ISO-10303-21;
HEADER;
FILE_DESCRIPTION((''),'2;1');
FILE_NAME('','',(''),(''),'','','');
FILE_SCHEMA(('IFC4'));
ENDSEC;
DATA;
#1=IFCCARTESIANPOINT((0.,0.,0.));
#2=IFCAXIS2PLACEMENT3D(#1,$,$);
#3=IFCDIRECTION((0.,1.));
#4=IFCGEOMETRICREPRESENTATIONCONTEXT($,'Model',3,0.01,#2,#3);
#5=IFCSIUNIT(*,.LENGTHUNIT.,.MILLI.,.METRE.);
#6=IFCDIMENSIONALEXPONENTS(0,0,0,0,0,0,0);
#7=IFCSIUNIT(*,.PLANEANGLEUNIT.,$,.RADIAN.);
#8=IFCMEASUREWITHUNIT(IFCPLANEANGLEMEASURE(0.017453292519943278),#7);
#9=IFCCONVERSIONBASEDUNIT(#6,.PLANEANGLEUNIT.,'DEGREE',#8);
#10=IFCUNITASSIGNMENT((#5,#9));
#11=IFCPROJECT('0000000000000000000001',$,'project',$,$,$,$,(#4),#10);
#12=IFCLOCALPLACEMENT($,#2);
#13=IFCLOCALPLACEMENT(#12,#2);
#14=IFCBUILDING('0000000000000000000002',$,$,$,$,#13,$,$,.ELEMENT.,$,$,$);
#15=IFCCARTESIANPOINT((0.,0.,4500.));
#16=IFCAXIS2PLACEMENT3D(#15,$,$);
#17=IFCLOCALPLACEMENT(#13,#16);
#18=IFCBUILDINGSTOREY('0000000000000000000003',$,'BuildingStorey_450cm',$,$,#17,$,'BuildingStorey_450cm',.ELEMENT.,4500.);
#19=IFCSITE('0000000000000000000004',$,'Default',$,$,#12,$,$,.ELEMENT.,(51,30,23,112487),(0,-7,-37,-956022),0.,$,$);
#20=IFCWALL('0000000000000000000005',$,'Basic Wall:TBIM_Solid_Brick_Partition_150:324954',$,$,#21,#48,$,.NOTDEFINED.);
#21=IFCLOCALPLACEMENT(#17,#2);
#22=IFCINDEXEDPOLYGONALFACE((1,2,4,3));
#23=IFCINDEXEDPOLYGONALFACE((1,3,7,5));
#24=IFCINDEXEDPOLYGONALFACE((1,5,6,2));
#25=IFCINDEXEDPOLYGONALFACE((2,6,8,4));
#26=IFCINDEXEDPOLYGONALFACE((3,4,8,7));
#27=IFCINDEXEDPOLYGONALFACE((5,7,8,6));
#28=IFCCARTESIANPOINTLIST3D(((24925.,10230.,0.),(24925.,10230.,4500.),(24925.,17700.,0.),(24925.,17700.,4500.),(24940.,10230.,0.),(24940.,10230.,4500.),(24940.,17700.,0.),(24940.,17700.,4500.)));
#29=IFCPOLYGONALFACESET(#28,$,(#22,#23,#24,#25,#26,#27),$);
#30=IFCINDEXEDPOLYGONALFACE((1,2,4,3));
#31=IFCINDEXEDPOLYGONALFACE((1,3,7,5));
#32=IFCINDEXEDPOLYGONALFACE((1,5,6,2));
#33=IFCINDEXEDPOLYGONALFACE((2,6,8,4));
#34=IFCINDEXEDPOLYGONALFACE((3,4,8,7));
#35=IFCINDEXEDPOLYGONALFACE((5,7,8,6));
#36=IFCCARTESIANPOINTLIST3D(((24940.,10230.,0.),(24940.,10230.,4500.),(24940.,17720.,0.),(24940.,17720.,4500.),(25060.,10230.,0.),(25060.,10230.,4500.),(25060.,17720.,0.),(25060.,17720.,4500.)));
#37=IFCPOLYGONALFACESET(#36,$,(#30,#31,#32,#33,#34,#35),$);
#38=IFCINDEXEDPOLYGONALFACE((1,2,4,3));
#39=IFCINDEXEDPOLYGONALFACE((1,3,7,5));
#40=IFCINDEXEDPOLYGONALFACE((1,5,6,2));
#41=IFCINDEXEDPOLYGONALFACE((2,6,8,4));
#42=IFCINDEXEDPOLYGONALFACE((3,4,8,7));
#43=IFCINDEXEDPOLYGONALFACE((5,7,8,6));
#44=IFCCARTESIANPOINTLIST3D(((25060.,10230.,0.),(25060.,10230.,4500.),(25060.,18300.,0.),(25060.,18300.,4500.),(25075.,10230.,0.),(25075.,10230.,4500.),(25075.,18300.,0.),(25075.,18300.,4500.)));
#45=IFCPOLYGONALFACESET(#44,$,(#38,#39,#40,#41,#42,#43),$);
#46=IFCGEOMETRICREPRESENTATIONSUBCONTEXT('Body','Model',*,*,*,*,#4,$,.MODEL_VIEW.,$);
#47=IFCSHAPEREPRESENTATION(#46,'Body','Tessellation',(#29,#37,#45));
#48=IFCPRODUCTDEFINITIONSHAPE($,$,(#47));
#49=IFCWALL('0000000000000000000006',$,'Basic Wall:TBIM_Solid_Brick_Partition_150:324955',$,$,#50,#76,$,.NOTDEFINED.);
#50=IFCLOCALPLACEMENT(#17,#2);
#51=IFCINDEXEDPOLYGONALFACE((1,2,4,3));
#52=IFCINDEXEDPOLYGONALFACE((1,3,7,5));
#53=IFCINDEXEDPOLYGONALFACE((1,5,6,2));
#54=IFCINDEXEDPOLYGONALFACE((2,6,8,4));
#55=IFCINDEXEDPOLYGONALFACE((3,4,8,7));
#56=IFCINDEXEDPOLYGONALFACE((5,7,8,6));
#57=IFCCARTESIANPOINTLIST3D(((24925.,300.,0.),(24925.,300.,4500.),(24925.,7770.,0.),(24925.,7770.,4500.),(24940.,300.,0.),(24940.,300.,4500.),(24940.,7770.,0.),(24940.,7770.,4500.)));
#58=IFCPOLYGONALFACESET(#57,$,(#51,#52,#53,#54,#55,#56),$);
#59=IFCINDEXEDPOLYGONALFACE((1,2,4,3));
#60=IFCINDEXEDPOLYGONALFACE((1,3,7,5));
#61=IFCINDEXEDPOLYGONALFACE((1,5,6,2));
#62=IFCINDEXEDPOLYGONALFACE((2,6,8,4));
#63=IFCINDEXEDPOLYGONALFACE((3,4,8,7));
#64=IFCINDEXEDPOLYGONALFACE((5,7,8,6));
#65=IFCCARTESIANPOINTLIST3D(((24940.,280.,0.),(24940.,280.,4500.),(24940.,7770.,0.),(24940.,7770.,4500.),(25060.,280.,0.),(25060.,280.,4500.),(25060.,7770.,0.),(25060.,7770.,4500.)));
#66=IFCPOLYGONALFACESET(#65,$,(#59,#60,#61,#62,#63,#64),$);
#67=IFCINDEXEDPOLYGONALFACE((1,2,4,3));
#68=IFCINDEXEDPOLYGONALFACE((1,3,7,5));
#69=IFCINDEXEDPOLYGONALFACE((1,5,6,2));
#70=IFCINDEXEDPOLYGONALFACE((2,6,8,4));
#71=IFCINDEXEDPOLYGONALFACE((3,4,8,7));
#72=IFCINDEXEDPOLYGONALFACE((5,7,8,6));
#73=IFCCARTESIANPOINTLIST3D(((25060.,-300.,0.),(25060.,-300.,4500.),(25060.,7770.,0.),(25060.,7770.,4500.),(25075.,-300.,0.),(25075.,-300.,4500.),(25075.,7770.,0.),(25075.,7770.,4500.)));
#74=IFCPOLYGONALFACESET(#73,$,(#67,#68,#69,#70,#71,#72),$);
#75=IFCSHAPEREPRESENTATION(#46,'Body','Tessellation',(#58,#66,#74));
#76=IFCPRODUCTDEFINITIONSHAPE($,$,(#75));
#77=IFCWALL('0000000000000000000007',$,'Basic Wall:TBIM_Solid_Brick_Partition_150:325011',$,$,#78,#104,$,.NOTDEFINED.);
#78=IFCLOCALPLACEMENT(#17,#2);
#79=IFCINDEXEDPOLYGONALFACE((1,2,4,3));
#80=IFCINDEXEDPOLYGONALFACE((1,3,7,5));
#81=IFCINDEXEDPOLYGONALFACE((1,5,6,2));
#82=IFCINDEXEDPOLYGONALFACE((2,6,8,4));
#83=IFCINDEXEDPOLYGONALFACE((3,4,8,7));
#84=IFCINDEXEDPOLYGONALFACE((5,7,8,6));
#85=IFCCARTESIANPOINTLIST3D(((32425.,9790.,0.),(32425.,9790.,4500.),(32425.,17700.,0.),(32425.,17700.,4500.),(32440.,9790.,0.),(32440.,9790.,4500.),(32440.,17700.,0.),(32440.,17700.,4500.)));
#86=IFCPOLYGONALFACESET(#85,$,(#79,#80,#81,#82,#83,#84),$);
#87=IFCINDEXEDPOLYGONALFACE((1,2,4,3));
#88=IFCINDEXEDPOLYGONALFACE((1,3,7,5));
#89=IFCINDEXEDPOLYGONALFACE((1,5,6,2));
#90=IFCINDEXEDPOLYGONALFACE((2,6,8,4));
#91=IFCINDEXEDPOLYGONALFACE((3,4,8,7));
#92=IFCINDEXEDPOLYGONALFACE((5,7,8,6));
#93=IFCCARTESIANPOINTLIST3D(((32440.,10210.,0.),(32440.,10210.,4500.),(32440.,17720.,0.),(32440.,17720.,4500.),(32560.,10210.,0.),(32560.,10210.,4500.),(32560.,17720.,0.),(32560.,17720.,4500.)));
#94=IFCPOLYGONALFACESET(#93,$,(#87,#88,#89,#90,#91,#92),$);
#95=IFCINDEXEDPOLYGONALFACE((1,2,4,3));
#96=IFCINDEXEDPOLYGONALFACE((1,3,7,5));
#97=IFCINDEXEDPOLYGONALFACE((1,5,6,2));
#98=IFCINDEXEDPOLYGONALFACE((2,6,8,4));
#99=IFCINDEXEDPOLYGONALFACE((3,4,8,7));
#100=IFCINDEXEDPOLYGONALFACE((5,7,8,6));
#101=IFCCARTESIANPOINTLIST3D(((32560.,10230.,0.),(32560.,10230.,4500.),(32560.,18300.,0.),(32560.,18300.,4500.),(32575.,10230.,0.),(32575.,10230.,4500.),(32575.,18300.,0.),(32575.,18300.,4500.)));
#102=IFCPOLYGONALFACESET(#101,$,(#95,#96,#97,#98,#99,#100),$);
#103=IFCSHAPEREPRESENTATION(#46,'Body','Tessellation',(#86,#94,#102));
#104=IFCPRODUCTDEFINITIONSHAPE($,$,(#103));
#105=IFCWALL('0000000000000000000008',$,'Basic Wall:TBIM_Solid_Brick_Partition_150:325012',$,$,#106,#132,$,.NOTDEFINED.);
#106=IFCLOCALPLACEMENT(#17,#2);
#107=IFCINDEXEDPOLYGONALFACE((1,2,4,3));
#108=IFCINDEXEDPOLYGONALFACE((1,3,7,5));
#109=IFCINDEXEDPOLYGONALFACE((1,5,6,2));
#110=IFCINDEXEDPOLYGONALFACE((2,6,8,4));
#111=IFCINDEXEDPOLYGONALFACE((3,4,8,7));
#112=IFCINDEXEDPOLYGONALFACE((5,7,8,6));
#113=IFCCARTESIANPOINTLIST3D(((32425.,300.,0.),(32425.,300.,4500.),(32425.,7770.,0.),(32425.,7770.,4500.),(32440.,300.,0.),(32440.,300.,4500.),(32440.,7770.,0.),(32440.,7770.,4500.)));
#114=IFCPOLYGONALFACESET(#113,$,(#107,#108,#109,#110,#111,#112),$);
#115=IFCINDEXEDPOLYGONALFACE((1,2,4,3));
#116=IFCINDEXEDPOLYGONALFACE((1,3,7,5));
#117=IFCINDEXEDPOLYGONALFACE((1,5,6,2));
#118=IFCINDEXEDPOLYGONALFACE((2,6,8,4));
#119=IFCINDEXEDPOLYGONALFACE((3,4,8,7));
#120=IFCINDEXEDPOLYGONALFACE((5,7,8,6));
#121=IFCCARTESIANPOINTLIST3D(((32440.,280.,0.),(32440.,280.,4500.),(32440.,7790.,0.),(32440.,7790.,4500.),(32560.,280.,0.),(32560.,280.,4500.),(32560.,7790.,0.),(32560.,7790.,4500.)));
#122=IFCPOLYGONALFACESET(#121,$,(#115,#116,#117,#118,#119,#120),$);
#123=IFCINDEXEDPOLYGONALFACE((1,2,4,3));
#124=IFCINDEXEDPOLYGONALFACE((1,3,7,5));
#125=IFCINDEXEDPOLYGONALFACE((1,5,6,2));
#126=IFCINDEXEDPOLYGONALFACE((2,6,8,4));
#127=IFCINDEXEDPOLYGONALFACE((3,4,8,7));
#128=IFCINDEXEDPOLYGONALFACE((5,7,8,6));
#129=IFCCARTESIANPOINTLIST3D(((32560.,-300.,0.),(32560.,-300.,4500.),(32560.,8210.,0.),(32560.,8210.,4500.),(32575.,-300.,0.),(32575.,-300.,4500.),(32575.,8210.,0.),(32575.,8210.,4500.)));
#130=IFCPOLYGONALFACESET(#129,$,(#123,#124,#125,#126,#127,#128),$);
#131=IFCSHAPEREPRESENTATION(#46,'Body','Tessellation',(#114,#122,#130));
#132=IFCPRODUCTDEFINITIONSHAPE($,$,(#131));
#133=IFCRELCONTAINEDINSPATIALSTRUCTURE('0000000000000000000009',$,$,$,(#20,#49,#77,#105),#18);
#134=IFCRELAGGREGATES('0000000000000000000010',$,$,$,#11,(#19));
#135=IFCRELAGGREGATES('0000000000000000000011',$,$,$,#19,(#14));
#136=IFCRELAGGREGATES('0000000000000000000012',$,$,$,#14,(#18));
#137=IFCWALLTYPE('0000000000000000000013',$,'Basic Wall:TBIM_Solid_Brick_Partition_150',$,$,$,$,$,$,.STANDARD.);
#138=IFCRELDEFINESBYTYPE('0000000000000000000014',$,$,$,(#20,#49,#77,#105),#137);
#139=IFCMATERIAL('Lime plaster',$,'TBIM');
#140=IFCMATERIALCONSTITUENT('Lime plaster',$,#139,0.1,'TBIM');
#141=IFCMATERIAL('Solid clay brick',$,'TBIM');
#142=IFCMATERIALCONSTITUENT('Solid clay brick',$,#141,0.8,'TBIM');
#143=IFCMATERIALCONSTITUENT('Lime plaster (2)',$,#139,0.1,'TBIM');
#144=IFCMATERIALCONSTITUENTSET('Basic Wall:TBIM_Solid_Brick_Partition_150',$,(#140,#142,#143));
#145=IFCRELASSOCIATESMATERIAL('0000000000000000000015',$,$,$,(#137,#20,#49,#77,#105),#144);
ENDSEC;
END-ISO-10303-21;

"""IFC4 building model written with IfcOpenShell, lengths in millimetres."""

from ifc_helpers import new_model, entity, si_unit, converted_unit, direction, frame, origin, place, context, subcontext, project, spatial, indexed_curve, outline, extrude, material, constituent, constituent_set, type_object, element, save


model = new_model("IFC4")

# Units and contexts
model_context = context("Model", 3, precision=0.01, world=origin(), true_north=direction((0.0, 1.0)))
body_context = subcontext(model_context, "Body", "Model", "MODEL_VIEW")
ifc_project = project(units=[si_unit("LENGTHUNIT", "METRE", prefix="MILLI"), converted_unit("PLANEANGLEUNIT", "DEGREE", entity("IfcPlaneAngleMeasure", 0.017453292519943278), si_unit("PLANEANGLEUNIT", "RADIAN"), dimensions=[0, 0, 0, 0, 0, 0, 0])], contexts=[model_context])

# Site, building, storey
site_placement = place(None, origin())
site = spatial("IfcSite", under=ifc_project, at=site_placement, Name="Default", CompositionType="ELEMENT", RefLatitude=(51, 30, 23, 112487), RefLongitude=(0, -7, -37, -956022), RefElevation=0.0)
building_placement = place(site_placement, origin())
building = spatial("IfcBuilding", under=site, at=building_placement, CompositionType="ELEMENT")
storey_placement = place(building_placement, frame((0.0, 0.0, 4500.0)))
storey = spatial("IfcBuildingStorey", under=building, at=storey_placement, Name="BuildingStorey_450cm", LongName="BuildingStorey_450cm", CompositionType="ELEMENT", Elevation=4500.0)

# Shared definitions
ifc_material_1 = material(Name="Solid clay brick", Category="TBIM")
ifc_material_2 = material(Name="Lime plaster", Category="TBIM")

# Walls
ifc_constituent_1 = constituent(ifc_material_2, Name="Lime plaster", Category="TBIM", fraction=0.1)
ifc_constituent_2 = constituent(ifc_material_1, Name="Solid clay brick", Category="TBIM", fraction=0.8)
ifc_constituent_3 = constituent(ifc_material_2, Name="Lime plaster (2)", Category="TBIM", fraction=0.1)
ifc_constituent_set_1 = constituent_set(constituents=[ifc_constituent_1, ifc_constituent_2, ifc_constituent_3], Name="Basic Wall:TBIM_Solid_Brick_Partition_150")
wall_type_1 = type_object("IfcWallType", Name="Basic Wall:TBIM_Solid_Brick_Partition_150", PredefinedType="STANDARD", material=ifc_constituent_set_1)
wall_1_placement = place(storey_placement, frame((25000.0, 10230.0, 0.0), z_axis=(0.0, 0.0, 1.0), x_axis=(0.0, 1.0, 0.0)))
element("IfcWall", 1, at=wall_1_placement, inside=storey, type_object=wall_type_1, material=ifc_constituent_set_1, Name="Basic Wall:TBIM_Solid_Brick_Partition_150:324954", PredefinedType="NOTDEFINED", context=body_context, shape_type="SweptSolid", body=[
    extrude(outline(indexed_curve([(-7.5, -3735.0), (7.5, -3735.0), (7.5, 3735.0), (-7.5, 3735.0), (-7.5, -3735.0)], self_intersect=False)), frame((3735.0, 67.5, 0.0), z_axis=(0.0, 0.0, 1.0), x_axis=(0.0, -1.0, 0.0)), (0.0, 0.0, 1.0), 4500.0),
    extrude(outline(indexed_curve([(-3745.0, -60.0), (3745.0, -60.0), (3745.0, 60.0), (-3745.0, 60.0), (-3745.0, -60.0)], self_intersect=False)), frame((3745.0, 0.0, 0.0)), (0.0, 0.0, 1.0), 4500.0),
    extrude(outline(indexed_curve([(-7.5, -4035.0), (7.5, -4035.0), (7.5, 4035.0), (-7.5, 4035.0), (-7.5, -4035.0)], self_intersect=False)), frame((4035.0, -67.5, 0.0), z_axis=(0.0, 0.0, 1.0), x_axis=(0.0, 1.0, 0.0)), (0.0, 0.0, 1.0), 4500.0),
])
wall_2_placement = place(storey_placement, frame((25000.0, 300.0, 0.0), z_axis=(0.0, 0.0, 1.0), x_axis=(0.0, 1.0, 0.0)))
element("IfcWall", 2, at=wall_2_placement, inside=storey, type_object=wall_type_1, material=ifc_constituent_set_1, Name="Basic Wall:TBIM_Solid_Brick_Partition_150:324955", PredefinedType="NOTDEFINED", context=body_context, shape_type="SweptSolid", body=[
    extrude(outline(indexed_curve([(-7.5, -3735.0), (7.5, -3735.0), (7.5, 3735.0), (-7.5, 3735.0), (-7.5, -3735.0)], self_intersect=False)), frame((3735.0, 67.5, 0.0), z_axis=(0.0, 0.0, 1.0), x_axis=(0.0, -1.0, 0.0)), (0.0, 0.0, 1.0), 4500.0),
    extrude(outline(indexed_curve([(-3745.0, -60.0), (3745.0, -60.0), (3745.0, 60.0), (-3745.0, 60.0), (-3745.0, -60.0)], self_intersect=False)), frame((3725.0, 0.0, 0.0)), (0.0, 0.0, 1.0), 4500.0),
    extrude(outline(indexed_curve([(-7.5, -4035.0), (7.5, -4035.0), (7.5, 4035.0), (-7.5, 4035.0), (-7.5, -4035.0)], self_intersect=False)), frame((3435.0, -67.5, 0.0), z_axis=(0.0, 0.0, 1.0), x_axis=(0.0, 1.0, 0.0)), (0.0, 0.0, 1.0), 4500.0),
])
wall_3_placement = place(storey_placement, frame((32500.0, 10230.0, 0.0), z_axis=(0.0, 0.0, 1.0), x_axis=(0.0, 1.0, 0.0)))
element("IfcWall", 3, at=wall_3_placement, inside=storey, type_object=wall_type_1, material=ifc_constituent_set_1, Name="Basic Wall:TBIM_Solid_Brick_Partition_150:325011", PredefinedType="NOTDEFINED", context=body_context, shape_type="SweptSolid", body=[
    extrude(outline(indexed_curve([(-7.5, -3955.0), (7.5, -3955.0), (7.5, 3955.0), (-7.5, 3955.0), (-7.5, -3955.0)], self_intersect=False)), frame((3515.0, 67.5, 0.0), z_axis=(0.0, 0.0, 1.0), x_axis=(0.0, -1.0, 0.0)), (0.0, 0.0, 1.0), 4500.0),
    extrude(outline(indexed_curve([(-3755.0, -60.0), (3755.0, -60.0), (3755.0, 60.0), (-3755.0, 60.0), (-3755.0, -60.0)], self_intersect=False)), frame((3735.0, 0.0, 0.0)), (0.0, 0.0, 1.0), 4500.0),
    extrude(outline(indexed_curve([(-7.5, -4035.0), (7.5, -4035.0), (7.5, 4035.0), (-7.5, 4035.0), (-7.5, -4035.0)], self_intersect=False)), frame((4035.0, -67.5, 0.0), z_axis=(0.0, 0.0, 1.0), x_axis=(0.0, 1.0, 0.0)), (0.0, 0.0, 1.0), 4500.0),
])
wall_4_placement = place(storey_placement, frame((32500.0, 300.0, 0.0), z_axis=(0.0, 0.0, 1.0), x_axis=(0.0, 1.0, 0.0)))
element("IfcWall", 4, at=wall_4_placement, inside=storey, type_object=wall_type_1, material=ifc_constituent_set_1, Name="Basic Wall:TBIM_Solid_Brick_Partition_150:325012", PredefinedType="NOTDEFINED", context=body_context, shape_type="SweptSolid", body=[
    extrude(outline(indexed_curve([(-7.5, -3735.0), (7.5, -3735.0), (7.5, 3735.0), (-7.5, 3735.0), (-7.5, -3735.0)], self_intersect=False)), frame((3735.0, 67.5, 0.0), z_axis=(0.0, 0.0, 1.0), x_axis=(0.0, -1.0, 0.0)), (0.0, 0.0, 1.0), 4500.0),
    extrude(outline(indexed_curve([(-3755.0, -60.0), (3755.0, -60.0), (3755.0, 60.0), (-3755.0, 60.0), (-3755.0, -60.0)], self_intersect=False)), frame((3735.0, 0.0, 0.0)), (0.0, 0.0, 1.0), 4500.0),
    extrude(outline(indexed_curve([(-7.5, -4255.0), (7.5, -4255.0), (7.5, 4255.0), (-7.5, 4255.0), (-7.5, -4255.0)], self_intersect=False)), frame((3655.0, -67.5, 0.0), z_axis=(0.0, 0.0, 1.0), x_axis=(0.0, 1.0, 0.0)), (0.0, 0.0, 1.0), 4500.0),
])

save(model, "model.ifc")
